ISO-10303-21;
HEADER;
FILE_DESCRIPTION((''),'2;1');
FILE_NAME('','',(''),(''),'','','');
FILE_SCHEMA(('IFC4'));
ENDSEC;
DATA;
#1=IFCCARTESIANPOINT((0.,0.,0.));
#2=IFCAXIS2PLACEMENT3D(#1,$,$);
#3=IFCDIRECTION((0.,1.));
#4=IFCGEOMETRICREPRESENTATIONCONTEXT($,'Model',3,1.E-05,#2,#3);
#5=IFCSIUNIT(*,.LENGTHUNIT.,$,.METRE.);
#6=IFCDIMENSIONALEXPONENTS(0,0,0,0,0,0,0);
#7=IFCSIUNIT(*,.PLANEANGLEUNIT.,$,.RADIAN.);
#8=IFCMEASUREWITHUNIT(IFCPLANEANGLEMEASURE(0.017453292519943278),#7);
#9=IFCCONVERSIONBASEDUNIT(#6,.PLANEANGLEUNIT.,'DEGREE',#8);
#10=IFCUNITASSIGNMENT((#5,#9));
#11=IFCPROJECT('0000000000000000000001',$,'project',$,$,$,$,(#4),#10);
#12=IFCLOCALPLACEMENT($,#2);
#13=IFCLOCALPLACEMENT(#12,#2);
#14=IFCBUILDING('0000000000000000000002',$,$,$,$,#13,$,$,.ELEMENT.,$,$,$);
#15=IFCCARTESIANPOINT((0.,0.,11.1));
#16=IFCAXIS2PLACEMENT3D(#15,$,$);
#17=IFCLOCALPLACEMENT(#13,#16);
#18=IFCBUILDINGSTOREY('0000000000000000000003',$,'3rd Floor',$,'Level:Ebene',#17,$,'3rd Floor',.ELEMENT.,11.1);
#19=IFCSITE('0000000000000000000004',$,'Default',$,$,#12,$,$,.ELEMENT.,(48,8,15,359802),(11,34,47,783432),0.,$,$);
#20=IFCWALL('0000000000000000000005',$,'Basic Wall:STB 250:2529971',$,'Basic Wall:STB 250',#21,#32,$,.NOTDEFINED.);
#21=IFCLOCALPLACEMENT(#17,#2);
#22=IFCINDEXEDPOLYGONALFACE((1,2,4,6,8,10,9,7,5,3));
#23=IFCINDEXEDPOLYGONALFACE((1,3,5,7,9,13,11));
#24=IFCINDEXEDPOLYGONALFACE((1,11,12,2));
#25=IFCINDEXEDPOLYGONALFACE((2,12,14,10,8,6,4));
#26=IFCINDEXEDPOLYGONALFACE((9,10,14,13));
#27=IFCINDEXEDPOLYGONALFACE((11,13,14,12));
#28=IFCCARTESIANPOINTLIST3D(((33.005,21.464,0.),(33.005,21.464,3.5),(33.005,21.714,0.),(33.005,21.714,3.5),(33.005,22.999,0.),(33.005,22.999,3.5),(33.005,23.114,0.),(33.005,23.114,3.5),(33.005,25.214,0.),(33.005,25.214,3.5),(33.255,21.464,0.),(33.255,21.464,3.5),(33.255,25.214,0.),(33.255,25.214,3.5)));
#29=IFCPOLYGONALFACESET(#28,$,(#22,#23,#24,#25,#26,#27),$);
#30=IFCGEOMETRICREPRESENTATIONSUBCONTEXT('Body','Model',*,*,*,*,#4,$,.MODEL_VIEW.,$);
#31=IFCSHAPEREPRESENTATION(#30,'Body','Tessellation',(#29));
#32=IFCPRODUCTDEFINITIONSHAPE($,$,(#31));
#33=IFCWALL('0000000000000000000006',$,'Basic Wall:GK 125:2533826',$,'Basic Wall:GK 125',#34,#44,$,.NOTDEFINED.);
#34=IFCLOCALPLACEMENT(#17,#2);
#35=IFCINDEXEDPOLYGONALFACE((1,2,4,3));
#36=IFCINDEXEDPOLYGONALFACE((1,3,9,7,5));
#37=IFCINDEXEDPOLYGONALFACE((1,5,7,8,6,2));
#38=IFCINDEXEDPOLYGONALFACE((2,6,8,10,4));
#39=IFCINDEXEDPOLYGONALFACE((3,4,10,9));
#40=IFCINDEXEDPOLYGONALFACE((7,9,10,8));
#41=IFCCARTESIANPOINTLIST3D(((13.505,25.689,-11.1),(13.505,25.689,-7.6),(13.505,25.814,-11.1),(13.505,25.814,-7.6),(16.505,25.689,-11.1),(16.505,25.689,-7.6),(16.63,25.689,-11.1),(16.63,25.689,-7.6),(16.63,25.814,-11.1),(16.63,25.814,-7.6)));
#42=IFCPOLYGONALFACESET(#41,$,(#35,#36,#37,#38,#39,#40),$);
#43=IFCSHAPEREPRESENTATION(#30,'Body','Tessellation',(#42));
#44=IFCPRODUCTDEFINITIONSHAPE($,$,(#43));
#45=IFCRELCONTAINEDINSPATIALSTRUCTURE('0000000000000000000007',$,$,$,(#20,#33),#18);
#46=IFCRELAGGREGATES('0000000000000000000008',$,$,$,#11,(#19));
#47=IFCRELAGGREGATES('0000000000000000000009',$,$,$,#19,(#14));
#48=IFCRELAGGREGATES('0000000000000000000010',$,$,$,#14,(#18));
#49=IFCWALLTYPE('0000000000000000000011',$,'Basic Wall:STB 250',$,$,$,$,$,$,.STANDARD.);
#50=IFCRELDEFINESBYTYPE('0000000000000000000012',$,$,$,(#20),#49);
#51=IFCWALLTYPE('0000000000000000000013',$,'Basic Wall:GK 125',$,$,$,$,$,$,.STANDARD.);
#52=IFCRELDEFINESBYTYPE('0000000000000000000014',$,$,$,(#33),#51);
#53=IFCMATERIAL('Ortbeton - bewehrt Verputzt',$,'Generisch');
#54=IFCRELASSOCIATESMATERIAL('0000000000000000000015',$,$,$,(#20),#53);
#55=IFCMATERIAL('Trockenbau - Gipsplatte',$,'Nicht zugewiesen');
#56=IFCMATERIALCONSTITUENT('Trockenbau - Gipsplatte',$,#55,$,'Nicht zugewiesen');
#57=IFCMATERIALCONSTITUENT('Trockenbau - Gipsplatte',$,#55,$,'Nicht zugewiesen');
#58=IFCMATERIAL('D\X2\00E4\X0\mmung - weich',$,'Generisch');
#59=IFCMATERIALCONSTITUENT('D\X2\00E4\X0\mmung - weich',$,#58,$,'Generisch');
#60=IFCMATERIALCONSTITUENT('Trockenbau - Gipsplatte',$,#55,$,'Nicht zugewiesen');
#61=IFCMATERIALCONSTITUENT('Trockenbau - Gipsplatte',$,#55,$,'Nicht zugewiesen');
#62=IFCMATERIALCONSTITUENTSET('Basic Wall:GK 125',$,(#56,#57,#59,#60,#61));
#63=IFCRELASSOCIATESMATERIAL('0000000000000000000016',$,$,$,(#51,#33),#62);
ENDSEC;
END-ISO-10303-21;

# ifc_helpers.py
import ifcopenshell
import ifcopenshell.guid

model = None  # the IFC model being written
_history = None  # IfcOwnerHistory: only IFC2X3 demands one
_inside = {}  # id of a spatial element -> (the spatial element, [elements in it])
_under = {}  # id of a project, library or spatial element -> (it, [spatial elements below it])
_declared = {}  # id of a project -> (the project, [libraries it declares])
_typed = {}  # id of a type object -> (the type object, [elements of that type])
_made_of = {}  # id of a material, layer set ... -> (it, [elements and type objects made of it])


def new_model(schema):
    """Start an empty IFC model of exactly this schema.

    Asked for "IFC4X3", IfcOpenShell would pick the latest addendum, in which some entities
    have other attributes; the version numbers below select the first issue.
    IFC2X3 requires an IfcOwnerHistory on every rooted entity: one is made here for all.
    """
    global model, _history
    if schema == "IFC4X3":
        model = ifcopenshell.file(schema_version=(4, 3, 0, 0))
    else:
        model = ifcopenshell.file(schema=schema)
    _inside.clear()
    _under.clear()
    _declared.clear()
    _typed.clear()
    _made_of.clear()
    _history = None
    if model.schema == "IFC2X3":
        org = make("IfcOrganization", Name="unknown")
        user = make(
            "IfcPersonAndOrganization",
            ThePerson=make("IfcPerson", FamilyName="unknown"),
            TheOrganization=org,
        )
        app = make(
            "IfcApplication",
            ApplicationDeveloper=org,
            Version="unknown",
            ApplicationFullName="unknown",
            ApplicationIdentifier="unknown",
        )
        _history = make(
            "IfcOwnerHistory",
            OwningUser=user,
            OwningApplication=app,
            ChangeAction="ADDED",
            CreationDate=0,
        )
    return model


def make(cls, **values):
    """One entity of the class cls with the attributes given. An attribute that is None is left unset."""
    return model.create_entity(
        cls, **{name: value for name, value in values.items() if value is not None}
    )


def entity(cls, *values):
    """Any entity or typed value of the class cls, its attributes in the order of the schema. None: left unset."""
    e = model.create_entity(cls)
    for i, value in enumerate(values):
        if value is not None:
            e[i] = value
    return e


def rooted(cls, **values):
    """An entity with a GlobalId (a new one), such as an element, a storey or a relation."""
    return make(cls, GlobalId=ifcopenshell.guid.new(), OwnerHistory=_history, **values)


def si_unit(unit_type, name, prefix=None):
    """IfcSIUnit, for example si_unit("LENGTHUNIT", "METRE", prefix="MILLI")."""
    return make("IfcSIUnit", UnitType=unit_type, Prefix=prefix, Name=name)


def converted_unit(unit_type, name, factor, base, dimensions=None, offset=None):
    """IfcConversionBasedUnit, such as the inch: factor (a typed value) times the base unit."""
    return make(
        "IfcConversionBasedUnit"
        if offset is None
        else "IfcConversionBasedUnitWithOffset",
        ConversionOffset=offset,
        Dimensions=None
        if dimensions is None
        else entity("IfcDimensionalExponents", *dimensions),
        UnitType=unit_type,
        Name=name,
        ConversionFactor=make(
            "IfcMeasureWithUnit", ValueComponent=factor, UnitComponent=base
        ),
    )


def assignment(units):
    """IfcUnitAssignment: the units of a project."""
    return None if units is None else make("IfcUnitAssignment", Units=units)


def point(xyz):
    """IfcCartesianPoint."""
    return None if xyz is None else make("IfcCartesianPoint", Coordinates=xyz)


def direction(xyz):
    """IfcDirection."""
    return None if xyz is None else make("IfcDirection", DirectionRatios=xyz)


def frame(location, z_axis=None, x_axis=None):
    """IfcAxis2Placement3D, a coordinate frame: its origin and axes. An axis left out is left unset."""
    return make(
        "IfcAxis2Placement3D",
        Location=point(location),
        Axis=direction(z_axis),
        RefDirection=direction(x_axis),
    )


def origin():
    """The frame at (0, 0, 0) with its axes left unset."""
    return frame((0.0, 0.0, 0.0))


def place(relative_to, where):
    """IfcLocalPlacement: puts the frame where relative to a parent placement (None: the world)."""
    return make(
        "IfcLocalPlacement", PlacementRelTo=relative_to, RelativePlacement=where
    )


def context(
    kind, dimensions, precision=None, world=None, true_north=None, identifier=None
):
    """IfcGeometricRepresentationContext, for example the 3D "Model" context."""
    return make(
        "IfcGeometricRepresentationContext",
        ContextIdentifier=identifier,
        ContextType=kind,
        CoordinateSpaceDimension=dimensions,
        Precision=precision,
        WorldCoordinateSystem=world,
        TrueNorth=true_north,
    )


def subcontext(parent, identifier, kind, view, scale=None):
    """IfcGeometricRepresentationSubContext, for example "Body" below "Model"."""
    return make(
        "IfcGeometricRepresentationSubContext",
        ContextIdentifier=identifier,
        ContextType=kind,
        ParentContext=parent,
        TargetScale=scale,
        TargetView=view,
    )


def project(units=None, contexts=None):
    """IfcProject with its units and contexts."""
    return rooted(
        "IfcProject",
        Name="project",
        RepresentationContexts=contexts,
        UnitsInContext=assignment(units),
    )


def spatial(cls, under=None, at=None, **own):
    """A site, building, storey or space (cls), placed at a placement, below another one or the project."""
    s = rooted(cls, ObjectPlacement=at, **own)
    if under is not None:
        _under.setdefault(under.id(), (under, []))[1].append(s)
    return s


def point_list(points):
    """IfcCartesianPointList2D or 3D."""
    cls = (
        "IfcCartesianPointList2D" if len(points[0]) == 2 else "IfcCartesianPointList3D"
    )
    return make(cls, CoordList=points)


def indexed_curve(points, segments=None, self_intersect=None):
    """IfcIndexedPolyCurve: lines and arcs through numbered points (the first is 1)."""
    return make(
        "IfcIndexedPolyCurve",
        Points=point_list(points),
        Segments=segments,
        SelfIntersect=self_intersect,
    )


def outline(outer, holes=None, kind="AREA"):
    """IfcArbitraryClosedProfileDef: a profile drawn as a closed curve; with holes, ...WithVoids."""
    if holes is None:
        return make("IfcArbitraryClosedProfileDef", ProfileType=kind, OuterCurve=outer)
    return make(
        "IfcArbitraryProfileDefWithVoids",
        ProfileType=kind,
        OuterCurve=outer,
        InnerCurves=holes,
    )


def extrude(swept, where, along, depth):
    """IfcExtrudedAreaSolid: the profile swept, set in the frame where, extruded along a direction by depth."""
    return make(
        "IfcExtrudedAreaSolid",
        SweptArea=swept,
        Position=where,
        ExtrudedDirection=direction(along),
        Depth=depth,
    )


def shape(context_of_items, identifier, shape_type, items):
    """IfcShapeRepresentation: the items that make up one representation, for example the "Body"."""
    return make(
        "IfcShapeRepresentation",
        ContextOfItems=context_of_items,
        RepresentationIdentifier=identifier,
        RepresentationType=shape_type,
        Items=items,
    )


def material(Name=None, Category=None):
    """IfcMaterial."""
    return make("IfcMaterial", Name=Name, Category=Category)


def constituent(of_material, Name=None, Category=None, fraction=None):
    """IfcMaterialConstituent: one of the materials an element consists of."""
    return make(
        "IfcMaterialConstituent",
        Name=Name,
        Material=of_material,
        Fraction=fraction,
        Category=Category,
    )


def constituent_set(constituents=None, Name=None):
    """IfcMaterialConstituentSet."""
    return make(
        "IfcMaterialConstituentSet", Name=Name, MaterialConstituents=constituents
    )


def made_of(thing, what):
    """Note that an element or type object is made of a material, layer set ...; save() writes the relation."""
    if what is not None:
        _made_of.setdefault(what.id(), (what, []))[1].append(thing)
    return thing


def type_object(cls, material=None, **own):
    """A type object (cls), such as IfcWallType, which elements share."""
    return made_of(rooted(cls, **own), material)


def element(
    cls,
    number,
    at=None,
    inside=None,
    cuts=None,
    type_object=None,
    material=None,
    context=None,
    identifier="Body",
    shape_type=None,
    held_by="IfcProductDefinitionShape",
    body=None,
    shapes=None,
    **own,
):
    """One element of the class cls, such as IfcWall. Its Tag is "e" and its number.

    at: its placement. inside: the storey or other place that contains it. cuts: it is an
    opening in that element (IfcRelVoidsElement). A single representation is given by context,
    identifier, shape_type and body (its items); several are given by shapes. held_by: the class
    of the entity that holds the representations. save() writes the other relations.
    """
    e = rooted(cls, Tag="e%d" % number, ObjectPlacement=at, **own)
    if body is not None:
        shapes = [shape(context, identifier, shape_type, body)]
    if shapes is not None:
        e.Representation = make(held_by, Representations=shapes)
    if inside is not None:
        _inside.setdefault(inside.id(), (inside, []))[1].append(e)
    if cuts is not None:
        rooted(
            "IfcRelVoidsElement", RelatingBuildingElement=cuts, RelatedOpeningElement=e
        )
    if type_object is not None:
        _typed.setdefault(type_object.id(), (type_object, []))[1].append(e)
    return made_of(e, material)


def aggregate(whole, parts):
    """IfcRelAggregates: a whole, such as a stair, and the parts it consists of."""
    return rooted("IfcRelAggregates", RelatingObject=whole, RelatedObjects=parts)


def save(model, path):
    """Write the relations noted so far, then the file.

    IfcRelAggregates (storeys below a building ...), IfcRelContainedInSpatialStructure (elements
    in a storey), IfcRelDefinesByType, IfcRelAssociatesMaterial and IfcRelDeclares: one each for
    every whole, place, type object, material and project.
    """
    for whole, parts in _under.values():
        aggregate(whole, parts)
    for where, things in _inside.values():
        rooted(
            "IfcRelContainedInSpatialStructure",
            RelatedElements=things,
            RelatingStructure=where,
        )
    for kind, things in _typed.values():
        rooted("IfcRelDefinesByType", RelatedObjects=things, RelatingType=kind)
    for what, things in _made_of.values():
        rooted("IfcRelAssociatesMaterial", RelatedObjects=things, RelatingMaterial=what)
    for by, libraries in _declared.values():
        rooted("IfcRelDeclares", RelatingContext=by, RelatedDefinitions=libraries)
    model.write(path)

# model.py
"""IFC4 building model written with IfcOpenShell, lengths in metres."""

from ifc_helpers import new_model, entity, si_unit, converted_unit, direction, frame, origin, place, context, subcontext, project, spatial, indexed_curve, outline, extrude, material, constituent, constituent_set, type_object, element, save


model = new_model("IFC4")

# Units and contexts
model_context = context("Model", 3, precision=1e-05, world=origin(), true_north=direction((0.0, 1.0)))
body_context = subcontext(model_context, "Body", "Model", "MODEL_VIEW")
ifc_project = project(units=[si_unit("LENGTHUNIT", "METRE"), converted_unit("PLANEANGLEUNIT", "DEGREE", entity("IfcPlaneAngleMeasure", 0.017453292519943278), si_unit("PLANEANGLEUNIT", "RADIAN"), dimensions=[0, 0, 0, 0, 0, 0, 0])], contexts=[model_context])

# Site, building, storey
site_placement = place(None, origin())
site = spatial("IfcSite", under=ifc_project, at=site_placement, Name="Default", CompositionType="ELEMENT", RefLatitude=(48, 8, 15, 359802), RefLongitude=(11, 34, 47, 783432), RefElevation=0.0)
building_placement = place(site_placement, origin())
building = spatial("IfcBuilding", under=site, at=building_placement, CompositionType="ELEMENT")
storey_placement = place(building_placement, frame((0.0, 0.0, 11.1)))
storey = spatial("IfcBuildingStorey", under=building, at=storey_placement, Name="3rd Floor", ObjectType="Level:Ebene", LongName="3rd Floor", CompositionType="ELEMENT", Elevation=11.1)

# Walls
ifc_material_1 = material(Name="Ortbeton - bewehrt Verputzt", Category="Generisch")
wall_type_1 = type_object("IfcWallType", Name="Basic Wall:STB 250", PredefinedType="STANDARD")
wall_1_placement = place(storey_placement, frame((33.13, 25.214, 0.0), z_axis=(0.0, 0.0, 1.0), x_axis=(0.0, -1.0, 0.0)))
element("IfcWall", 1, at=wall_1_placement, inside=storey, type_object=wall_type_1, material=ifc_material_1, Name="Basic Wall:STB 250:2529971", ObjectType="Basic Wall:STB 250", PredefinedType="NOTDEFINED", context=body_context, shape_type="SweptSolid", body=[
    extrude(outline(indexed_curve([(3.75, -0.125), (3.75, 0.125), (0.0, 0.125), (0.0, -0.125), (2.1, -0.125), (2.215, -0.125), (3.5, -0.125), (3.75, -0.125)], self_intersect=False)), origin(), (0.0, 0.0, 1.0), 3.5),
])
ifc_material_2 = material(Name="Trockenbau - Gipsplatte", Category="Nicht zugewiesen")
ifc_constituent_1 = constituent(ifc_material_2, Name="Trockenbau - Gipsplatte", Category="Nicht zugewiesen")
ifc_constituent_2 = constituent(ifc_material_2, Name="Trockenbau - Gipsplatte", Category="Nicht zugewiesen")
ifc_material_3 = material(Name="Dämmung - weich", Category="Generisch")
ifc_constituent_3 = constituent(ifc_material_3, Name="Dämmung - weich", Category="Generisch")
ifc_constituent_4 = constituent(ifc_material_2, Name="Trockenbau - Gipsplatte", Category="Nicht zugewiesen")
ifc_constituent_5 = constituent(ifc_material_2, Name="Trockenbau - Gipsplatte", Category="Nicht zugewiesen")
ifc_constituent_set = constituent_set(constituents=[ifc_constituent_1, ifc_constituent_2, ifc_constituent_3, ifc_constituent_4, ifc_constituent_5], Name="Basic Wall:GK 125")
wall_type_2 = type_object("IfcWallType", Name="Basic Wall:GK 125", PredefinedType="STANDARD", material=ifc_constituent_set)
wall_2_placement = place(storey_placement, frame((13.505, 25.7515, -11.1)))
element("IfcWall", 2, at=wall_2_placement, inside=storey, type_object=wall_type_2, material=ifc_constituent_set, Name="Basic Wall:GK 125:2533826", ObjectType="Basic Wall:GK 125", PredefinedType="NOTDEFINED", context=body_context, shape_type="SweptSolid", body=[
    extrude(outline(indexed_curve([(3.125, -0.0625), (3.125, 0.0625), (0.0, 0.0625), (0.0, -0.0625), (3.0, -0.0625), (3.125, -0.0625)], self_intersect=False)), origin(), (0.0, 0.0, 1.0), 3.5),
])

save(model, "model.ifc")
